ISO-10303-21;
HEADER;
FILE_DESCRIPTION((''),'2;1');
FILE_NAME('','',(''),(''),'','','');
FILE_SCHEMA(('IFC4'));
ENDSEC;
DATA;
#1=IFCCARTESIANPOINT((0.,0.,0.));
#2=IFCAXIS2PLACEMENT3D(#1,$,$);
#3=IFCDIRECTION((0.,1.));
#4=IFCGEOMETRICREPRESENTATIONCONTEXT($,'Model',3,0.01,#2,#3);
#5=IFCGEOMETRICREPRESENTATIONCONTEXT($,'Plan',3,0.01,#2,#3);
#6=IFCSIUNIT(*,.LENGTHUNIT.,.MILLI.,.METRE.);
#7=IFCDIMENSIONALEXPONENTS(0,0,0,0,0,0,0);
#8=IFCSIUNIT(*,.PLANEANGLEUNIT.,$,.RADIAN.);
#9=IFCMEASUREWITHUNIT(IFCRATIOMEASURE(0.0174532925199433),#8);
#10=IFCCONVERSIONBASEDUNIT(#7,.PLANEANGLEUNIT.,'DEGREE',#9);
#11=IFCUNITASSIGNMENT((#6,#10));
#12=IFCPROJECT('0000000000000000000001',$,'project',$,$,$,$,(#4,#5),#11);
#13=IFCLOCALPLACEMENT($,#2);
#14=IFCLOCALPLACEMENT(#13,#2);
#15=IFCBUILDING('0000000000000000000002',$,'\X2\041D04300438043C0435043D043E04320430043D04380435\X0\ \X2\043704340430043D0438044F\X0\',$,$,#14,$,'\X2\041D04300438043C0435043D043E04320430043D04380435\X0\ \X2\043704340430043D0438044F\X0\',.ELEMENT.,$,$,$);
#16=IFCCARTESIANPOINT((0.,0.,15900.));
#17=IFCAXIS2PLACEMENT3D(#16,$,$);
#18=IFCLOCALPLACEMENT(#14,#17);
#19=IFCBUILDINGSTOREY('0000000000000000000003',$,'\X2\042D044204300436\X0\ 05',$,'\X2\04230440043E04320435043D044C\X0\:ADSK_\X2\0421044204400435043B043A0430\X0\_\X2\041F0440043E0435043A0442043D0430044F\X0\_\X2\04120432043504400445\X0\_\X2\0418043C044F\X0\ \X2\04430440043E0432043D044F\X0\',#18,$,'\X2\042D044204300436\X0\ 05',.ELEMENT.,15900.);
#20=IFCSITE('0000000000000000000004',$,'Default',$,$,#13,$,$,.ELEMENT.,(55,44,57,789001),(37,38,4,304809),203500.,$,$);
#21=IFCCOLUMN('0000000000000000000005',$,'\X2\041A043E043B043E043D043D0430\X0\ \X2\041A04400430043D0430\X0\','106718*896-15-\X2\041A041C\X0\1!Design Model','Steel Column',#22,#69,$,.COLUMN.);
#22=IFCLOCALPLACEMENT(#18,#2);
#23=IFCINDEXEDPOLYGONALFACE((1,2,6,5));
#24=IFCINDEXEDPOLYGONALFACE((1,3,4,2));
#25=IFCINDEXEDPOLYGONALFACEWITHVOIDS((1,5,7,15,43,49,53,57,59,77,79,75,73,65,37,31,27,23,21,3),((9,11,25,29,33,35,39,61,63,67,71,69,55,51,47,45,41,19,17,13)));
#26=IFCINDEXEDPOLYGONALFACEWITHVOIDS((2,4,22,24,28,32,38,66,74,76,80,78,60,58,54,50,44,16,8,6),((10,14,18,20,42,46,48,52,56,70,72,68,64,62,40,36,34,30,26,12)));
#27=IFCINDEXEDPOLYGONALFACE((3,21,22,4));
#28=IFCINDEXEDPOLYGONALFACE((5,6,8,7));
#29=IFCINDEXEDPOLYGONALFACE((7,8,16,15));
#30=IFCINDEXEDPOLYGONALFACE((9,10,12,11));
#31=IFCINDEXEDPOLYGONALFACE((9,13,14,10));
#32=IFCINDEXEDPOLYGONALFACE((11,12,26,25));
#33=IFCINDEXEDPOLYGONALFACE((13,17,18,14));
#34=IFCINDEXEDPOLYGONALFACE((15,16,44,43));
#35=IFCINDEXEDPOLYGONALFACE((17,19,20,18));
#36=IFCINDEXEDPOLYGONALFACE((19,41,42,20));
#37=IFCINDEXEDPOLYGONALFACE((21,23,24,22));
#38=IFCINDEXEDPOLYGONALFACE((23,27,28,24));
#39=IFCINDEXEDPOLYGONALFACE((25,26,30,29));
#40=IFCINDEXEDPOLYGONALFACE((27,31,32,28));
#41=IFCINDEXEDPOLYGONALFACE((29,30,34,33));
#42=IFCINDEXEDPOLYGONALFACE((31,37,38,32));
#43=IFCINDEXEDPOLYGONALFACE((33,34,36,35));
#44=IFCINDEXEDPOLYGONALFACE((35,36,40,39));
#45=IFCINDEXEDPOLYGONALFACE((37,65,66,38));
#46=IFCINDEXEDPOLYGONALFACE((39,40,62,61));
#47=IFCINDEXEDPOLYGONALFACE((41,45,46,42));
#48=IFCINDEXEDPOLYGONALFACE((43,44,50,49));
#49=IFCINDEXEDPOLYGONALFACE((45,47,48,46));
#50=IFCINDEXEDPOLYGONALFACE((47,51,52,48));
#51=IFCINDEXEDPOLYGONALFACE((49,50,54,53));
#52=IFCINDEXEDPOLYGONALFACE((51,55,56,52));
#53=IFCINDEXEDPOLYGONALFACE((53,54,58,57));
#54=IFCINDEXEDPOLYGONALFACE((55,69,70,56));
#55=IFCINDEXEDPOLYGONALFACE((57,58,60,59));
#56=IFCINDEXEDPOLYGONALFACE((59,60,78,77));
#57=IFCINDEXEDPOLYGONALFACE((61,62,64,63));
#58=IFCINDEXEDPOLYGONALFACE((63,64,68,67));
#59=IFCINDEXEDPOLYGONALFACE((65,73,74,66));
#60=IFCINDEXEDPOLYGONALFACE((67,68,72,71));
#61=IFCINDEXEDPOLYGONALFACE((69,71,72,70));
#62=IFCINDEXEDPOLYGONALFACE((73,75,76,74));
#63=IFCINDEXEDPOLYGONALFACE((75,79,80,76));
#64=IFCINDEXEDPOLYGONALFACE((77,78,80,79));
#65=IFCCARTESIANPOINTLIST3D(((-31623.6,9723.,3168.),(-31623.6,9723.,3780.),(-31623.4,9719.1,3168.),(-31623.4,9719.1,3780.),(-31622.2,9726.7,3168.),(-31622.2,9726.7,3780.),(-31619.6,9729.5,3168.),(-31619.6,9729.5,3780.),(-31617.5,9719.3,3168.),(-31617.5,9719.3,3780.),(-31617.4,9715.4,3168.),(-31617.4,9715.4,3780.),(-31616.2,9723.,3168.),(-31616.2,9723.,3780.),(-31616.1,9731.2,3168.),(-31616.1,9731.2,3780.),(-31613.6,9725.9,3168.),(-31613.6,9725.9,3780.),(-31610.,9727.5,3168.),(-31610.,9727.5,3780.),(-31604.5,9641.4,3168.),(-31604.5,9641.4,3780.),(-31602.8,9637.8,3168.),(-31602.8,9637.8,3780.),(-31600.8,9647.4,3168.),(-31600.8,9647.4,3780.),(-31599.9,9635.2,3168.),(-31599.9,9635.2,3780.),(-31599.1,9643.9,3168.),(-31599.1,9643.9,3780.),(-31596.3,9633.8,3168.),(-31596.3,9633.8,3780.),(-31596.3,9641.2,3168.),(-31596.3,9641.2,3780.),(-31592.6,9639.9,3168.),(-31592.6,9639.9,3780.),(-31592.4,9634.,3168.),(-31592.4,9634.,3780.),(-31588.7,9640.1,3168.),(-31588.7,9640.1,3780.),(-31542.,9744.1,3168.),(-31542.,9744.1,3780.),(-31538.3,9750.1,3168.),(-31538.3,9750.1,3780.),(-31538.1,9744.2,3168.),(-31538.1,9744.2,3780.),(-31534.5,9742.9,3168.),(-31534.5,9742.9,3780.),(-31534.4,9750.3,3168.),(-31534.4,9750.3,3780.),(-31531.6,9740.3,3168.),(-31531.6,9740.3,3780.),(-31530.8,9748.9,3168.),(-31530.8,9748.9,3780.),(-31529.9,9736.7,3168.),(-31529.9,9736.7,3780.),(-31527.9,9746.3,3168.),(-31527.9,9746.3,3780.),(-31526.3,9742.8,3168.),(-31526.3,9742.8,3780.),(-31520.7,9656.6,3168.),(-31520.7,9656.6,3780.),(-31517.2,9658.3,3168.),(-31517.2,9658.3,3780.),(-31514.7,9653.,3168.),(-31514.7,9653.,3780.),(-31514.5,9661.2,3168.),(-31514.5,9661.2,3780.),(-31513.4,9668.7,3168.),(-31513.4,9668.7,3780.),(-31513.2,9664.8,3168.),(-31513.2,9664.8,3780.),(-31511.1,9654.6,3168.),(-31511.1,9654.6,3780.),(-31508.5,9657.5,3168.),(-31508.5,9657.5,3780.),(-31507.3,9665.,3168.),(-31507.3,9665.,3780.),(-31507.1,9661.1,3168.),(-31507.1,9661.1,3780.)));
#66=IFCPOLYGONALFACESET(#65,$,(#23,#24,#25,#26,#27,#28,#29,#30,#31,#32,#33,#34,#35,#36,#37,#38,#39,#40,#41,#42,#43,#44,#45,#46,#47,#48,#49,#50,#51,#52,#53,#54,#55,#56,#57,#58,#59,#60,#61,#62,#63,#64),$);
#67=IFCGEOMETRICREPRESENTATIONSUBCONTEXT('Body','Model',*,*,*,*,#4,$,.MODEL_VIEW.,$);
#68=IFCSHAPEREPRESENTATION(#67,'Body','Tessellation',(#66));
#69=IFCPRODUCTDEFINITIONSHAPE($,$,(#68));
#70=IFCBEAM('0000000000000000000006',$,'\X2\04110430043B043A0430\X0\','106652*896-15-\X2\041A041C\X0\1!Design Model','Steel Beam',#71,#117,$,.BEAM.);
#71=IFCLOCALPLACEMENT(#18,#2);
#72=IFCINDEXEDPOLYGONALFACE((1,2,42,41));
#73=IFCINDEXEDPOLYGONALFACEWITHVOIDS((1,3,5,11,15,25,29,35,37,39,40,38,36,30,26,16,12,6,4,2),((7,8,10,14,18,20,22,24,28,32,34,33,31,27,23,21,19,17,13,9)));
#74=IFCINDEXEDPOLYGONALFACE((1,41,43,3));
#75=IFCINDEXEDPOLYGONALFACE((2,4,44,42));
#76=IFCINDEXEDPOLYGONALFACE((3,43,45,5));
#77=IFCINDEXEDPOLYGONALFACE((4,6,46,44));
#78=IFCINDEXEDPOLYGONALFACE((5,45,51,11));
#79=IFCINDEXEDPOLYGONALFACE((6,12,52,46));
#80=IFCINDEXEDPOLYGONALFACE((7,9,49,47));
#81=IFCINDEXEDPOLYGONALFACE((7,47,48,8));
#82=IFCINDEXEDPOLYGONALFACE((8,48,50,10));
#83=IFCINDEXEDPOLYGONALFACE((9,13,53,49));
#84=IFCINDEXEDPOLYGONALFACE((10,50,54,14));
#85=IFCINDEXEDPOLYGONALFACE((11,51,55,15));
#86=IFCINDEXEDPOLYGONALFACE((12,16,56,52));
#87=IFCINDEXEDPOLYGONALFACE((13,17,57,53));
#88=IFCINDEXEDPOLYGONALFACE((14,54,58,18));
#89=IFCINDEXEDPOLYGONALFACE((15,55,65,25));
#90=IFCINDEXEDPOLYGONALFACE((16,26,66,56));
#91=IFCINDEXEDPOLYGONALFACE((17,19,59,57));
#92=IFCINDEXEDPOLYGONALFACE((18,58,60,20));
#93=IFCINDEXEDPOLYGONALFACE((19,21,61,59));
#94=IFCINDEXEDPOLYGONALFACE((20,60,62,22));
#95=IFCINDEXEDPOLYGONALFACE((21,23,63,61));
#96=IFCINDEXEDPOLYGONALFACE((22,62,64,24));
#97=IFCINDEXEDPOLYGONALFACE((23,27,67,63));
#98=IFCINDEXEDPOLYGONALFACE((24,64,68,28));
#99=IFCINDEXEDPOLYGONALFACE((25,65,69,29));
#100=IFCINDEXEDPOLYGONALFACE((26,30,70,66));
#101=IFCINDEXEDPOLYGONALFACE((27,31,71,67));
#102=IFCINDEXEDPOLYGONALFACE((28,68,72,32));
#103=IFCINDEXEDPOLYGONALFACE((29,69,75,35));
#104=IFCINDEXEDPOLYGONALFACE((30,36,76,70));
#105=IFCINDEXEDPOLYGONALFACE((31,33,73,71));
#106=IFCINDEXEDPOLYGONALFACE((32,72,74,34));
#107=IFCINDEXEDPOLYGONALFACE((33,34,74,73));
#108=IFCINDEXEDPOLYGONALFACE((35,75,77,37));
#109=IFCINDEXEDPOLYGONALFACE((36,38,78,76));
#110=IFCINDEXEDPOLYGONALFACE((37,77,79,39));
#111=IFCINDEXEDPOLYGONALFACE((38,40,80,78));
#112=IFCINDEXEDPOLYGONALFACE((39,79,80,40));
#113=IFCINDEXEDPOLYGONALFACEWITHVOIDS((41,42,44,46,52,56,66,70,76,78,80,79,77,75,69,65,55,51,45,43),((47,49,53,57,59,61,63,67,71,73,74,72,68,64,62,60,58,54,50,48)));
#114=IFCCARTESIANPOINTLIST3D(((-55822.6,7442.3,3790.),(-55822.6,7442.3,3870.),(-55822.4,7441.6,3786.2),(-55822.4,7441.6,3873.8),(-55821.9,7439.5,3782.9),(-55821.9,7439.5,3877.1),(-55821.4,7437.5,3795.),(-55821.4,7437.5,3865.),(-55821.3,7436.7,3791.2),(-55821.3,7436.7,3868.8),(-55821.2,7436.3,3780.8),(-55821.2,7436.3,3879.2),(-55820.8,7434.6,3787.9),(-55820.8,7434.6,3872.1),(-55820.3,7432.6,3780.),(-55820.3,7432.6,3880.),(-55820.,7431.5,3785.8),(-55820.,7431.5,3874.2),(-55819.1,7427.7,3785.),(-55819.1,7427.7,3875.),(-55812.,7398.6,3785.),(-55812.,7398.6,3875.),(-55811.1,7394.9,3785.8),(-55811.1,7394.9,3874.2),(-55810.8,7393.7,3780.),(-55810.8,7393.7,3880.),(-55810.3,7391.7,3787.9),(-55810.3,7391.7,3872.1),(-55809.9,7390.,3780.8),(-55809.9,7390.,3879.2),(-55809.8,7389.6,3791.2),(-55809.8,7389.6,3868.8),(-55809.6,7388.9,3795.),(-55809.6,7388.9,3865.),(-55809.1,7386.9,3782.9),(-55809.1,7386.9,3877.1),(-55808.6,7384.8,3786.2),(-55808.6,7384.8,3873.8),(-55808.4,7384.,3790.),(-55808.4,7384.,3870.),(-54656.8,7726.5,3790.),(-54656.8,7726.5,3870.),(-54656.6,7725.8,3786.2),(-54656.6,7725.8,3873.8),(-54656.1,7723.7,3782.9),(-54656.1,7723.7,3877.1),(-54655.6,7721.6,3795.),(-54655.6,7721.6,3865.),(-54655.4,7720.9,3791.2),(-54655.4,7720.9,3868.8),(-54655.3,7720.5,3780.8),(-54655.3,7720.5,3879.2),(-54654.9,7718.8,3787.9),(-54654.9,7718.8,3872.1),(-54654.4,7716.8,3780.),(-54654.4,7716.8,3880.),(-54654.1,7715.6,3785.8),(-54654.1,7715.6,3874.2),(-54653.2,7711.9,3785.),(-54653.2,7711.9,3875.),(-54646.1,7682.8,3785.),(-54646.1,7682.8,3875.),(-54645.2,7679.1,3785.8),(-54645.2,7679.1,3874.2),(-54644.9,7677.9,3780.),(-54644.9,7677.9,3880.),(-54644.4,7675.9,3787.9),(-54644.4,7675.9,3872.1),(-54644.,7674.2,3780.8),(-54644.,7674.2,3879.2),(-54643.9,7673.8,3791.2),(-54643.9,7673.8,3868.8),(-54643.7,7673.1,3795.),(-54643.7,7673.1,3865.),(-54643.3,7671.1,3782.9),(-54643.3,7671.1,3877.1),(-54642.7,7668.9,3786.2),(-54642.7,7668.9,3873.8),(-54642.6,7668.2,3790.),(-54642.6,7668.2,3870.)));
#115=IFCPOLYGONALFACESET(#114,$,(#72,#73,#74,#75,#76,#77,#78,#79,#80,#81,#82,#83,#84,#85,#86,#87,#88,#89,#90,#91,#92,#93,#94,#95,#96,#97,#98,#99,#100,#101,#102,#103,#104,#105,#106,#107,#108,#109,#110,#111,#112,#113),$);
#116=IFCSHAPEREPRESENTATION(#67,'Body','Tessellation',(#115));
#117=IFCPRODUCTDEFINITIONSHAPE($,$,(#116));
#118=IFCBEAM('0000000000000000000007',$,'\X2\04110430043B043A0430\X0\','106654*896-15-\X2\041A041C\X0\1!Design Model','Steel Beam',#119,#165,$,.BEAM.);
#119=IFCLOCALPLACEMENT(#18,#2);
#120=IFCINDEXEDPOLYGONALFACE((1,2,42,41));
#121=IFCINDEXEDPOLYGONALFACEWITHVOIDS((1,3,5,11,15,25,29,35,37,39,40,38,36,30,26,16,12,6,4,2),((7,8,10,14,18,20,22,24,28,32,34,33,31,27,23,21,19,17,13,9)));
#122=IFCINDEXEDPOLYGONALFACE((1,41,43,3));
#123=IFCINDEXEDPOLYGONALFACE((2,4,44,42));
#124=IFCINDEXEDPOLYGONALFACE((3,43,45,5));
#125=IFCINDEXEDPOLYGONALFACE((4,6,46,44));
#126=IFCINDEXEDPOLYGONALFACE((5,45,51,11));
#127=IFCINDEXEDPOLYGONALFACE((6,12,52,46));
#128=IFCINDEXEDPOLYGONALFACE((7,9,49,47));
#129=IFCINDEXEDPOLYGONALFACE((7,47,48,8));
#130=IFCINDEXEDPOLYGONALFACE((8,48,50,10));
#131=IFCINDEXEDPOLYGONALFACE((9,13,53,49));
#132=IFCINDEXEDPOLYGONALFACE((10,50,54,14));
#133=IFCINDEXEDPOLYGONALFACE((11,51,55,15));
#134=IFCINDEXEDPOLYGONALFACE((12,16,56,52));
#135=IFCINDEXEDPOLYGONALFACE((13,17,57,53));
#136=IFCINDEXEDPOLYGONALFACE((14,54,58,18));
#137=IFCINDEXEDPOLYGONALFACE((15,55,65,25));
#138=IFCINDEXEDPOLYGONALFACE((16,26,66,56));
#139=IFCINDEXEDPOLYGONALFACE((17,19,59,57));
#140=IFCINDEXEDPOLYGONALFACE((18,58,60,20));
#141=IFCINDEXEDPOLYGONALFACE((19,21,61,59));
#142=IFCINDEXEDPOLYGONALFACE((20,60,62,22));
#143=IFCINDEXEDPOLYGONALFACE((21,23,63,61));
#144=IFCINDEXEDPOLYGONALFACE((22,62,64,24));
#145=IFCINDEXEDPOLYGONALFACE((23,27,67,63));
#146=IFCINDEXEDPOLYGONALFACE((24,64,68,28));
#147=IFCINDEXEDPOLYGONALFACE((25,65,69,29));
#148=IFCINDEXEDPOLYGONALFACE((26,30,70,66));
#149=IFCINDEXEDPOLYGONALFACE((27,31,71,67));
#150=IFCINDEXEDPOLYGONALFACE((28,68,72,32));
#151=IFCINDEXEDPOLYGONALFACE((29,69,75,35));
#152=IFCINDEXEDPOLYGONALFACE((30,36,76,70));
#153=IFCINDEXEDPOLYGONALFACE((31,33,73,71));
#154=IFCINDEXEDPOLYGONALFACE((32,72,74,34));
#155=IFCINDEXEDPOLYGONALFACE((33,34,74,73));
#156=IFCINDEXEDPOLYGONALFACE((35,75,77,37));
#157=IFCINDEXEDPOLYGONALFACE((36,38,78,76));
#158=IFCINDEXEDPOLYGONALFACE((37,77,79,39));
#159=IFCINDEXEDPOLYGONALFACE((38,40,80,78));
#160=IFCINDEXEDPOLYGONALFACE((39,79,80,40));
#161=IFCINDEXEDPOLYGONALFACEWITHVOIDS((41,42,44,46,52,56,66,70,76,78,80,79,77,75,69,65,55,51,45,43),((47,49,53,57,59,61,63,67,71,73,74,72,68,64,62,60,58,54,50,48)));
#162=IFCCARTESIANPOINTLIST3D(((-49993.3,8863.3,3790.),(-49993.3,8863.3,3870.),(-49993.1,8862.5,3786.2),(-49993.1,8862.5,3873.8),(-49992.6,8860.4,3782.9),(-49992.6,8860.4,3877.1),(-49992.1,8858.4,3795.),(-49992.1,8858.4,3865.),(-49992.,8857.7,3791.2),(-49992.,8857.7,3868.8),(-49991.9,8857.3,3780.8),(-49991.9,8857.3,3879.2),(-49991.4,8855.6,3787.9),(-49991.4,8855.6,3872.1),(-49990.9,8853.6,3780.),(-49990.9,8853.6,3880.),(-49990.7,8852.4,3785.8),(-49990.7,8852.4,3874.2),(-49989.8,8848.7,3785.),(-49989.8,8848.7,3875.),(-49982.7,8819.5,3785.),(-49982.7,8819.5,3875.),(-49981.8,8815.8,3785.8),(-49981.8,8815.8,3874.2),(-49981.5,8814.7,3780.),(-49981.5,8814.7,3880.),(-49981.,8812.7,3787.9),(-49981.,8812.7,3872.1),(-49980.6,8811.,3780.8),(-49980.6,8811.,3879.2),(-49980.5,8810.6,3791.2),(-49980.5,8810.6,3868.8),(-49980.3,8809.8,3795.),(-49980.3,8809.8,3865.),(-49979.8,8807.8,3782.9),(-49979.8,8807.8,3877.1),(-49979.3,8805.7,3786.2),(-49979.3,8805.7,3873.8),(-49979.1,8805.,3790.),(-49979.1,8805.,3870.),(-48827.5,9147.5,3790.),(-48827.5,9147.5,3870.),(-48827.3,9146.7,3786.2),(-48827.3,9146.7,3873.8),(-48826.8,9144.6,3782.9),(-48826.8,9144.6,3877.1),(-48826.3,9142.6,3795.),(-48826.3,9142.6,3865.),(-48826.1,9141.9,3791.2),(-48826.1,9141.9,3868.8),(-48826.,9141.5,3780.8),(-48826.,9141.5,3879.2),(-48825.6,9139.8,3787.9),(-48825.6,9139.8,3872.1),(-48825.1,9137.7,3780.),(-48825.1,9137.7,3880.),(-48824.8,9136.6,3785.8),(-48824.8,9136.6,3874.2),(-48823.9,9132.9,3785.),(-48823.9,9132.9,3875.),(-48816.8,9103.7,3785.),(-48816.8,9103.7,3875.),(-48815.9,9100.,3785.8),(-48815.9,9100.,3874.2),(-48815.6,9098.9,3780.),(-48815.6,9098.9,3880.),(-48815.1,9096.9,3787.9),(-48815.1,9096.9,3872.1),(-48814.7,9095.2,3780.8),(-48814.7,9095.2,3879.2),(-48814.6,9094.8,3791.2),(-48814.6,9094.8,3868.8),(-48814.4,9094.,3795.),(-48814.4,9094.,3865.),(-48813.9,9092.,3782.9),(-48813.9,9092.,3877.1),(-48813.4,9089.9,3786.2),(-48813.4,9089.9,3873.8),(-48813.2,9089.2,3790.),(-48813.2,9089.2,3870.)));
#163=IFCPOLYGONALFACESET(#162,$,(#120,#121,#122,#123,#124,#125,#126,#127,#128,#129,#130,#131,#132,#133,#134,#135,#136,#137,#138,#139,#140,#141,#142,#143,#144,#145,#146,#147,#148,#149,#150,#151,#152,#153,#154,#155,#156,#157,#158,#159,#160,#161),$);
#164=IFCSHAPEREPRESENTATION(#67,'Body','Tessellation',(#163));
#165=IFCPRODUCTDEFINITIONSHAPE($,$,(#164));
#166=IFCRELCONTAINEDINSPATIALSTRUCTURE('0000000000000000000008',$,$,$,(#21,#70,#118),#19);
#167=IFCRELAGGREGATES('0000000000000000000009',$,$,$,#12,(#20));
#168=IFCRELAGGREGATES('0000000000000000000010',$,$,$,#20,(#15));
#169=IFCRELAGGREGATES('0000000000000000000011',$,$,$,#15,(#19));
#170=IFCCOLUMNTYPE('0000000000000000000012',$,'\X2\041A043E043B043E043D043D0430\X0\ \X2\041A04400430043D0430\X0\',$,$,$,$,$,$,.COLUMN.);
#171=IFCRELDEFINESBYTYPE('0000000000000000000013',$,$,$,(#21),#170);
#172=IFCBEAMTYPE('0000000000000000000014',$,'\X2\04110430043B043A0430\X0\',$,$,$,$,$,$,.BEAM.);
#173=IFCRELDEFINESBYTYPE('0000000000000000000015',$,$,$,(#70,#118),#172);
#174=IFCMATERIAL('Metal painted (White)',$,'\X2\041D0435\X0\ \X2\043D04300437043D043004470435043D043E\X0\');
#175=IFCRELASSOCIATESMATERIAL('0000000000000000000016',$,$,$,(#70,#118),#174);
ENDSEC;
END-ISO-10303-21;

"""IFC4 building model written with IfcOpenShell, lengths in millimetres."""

from ifc_helpers import new_model, entity, si_unit, converted_unit, direction, frame, origin, place, context, subcontext, project, spatial, indexed_curve, outline, extrude, material, type_object, element, save


model = new_model("IFC4")

# Units and contexts
model_context = context("Model", 3, precision=0.01, world=origin(), true_north=direction((0.0, 1.0)))
plan_context = context("Plan", 3, precision=0.01, world=origin(), true_north=direction((0.0, 1.0)))
body_context = subcontext(model_context, "Body", "Model", "MODEL_VIEW")
ifc_project = project(units=[si_unit("LENGTHUNIT", "METRE", prefix="MILLI"), converted_unit("PLANEANGLEUNIT", "DEGREE", entity("IfcRatioMeasure", 0.0174532925199433), si_unit("PLANEANGLEUNIT", "RADIAN"), dimensions=[0, 0, 0, 0, 0, 0, 0])], contexts=[model_context, plan_context])

# Site, building, storey
site_placement = place(None, origin())
site = spatial("IfcSite", under=ifc_project, at=site_placement, Name="Default", CompositionType="ELEMENT", RefLatitude=(55, 44, 57, 789001), RefLongitude=(37, 38, 4, 304809), RefElevation=203500.0)
building_placement = place(site_placement, origin())
building = spatial("IfcBuilding", under=site, at=building_placement, Name="Наименование здания", LongName="Наименование здания", CompositionType="ELEMENT")
storey_placement = place(building_placement, frame((0.0, 0.0, 15900.0)))
storey = spatial("IfcBuildingStorey", under=building, at=storey_placement, Name="Этаж 05", ObjectType="Уровень:ADSK_Стрелка_Проектная_Вверх_Имя уровня", LongName="Этаж 05", CompositionType="ELEMENT", Elevation=15900.0)

# Column
column_type_1 = type_object("IfcColumnType", Name="Колонна Крана", PredefinedType="COLUMN")
column_1_placement = place(storey_placement, origin())
element("IfcColumn", 1, at=column_1_placement, inside=storey, type_object=column_type_1, Name="Колонна Крана", Description="106718*896-15-КМ1!Design Model", ObjectType="Steel Column", PredefinedType="COLUMN", context=body_context, shape_type="SweptSolid", body=[
    extrude(outline(indexed_curve([(29.5, -56.8), (33.4, -56.8), (37.0, -55.3), (39.7, -52.6), (41.2, -49.0), (56.8, 29.5), (56.8, 33.4), (55.3, 37.0), (52.6, 39.7), (49.0, 41.2), (-29.5, 56.8), (-33.4, 56.8), (-37.0, 55.3), (-39.7, 52.6), (-41.2, 49.0), (-56.8, -29.5), (-56.8, -33.4), (-55.3, -37.0), (-52.6, -39.7), (-49.0, -41.2), (29.5, -56.8)], self_intersect=False), holes=[indexed_curve([(-43.1, -37.3), (-46.7, -35.8), (-49.5, -33.1), (-51.0, -29.5), (-51.0, -25.5), (-37.3, 43.1), (-35.8, 46.7), (-33.1, 49.5), (-29.5, 51.0), (-25.5, 51.0), (43.1, 37.3), (46.7, 35.8), (49.5, 33.1), (51.0, 29.5), (51.0, 25.5), (37.3, -43.1), (35.8, -46.7), (33.1, -49.5), (29.5, -51.0), (25.5, -51.0), (-43.1, -37.3)], self_intersect=False)]), frame((-31565.4, 9692.1, 3168.0), z_axis=(0.0, 0.0, 1.0), x_axis=(-0.906681, -0.421816, 0.0)), (0.0, 0.0, 1.0), 612.0),
])

# Beams
ifc_material = material(Name="Metal painted (White)", Category="Не назначено")
beam_type = type_object("IfcBeamType", Name="Балка", PredefinedType="BEAM")
beam_1_placement = place(storey_placement, origin())
element("IfcBeam", 2, at=beam_1_placement, inside=storey, type_object=beam_type, material=ifc_material, Name="Балка", Description="106652*896-15-КМ1!Design Model", ObjectType="Steel Beam", PredefinedType="BEAM", context=body_context, shape_type="SweptSolid", body=[
    extrude(outline(indexed_curve([(9.9, -52.9), (13.8, -52.9), (17.4, -51.4), (20.1, -48.7), (21.6, -45.1), (37.2, 33.4), (37.2, 37.3), (35.7, 40.9), (33.0, 43.6), (29.4, 45.1), (-9.9, 52.9), (-13.8, 52.9), (-17.4, 51.4), (-20.1, 48.7), (-21.6, 45.1), (-37.2, -33.4), (-37.2, -37.3), (-35.7, -40.9), (-33.0, -43.6), (-29.4, -45.1), (9.9, -52.9)], self_intersect=False), holes=[indexed_curve([(-31.3, -29.5), (-17.7, 39.2), (-16.2, 42.8), (-13.4, 45.6), (-9.8, 47.1), (-5.9, 47.1), (23.5, 41.2), (27.1, 39.7), (29.9, 37.0), (31.3, 33.4), (31.3, 29.5), (17.7, -39.2), (16.2, -42.8), (13.4, -45.6), (9.8, -47.1), (5.9, -47.1), (-23.5, -41.2), (-27.1, -39.7), (-29.9, -37.0), (-31.3, -33.4), (-31.3, -29.5)], self_intersect=False)]), frame((-55815.5, 7413.2, 3830.0), z_axis=(0.971552, 0.236826, 0.0), x_axis=(-0.232276, 0.952884, 0.19509)), (0.0, 0.0, 1.0), 1200.0),
])
beam_2_placement = place(storey_placement, origin())
element("IfcBeam", 3, at=beam_2_placement, inside=storey, type_object=beam_type, material=ifc_material, Name="Балка", Description="106654*896-15-КМ1!Design Model", ObjectType="Steel Beam", PredefinedType="BEAM", context=body_context, shape_type="SweptSolid", body=[
    extrude(outline(indexed_curve([(9.9, -52.9), (13.8, -52.9), (17.4, -51.4), (20.1, -48.7), (21.6, -45.1), (37.2, 33.4), (37.2, 37.3), (35.7, 40.9), (33.0, 43.6), (29.4, 45.1), (-9.9, 52.9), (-13.8, 52.9), (-17.4, 51.4), (-20.1, 48.7), (-21.6, 45.1), (-37.2, -33.4), (-37.2, -37.3), (-35.7, -40.9), (-33.0, -43.6), (-29.4, -45.1), (9.9, -52.9)], self_intersect=False), holes=[indexed_curve([(-31.3, -29.5), (-17.7, 39.2), (-16.2, 42.8), (-13.4, 45.6), (-9.8, 47.1), (-5.9, 47.1), (23.5, 41.2), (27.1, 39.7), (29.9, 37.0), (31.3, 33.4), (31.3, 29.5), (17.7, -39.2), (16.2, -42.8), (13.4, -45.6), (9.8, -47.1), (5.9, -47.1), (-23.5, -41.2), (-27.1, -39.7), (-29.9, -37.0), (-31.3, -33.4), (-31.3, -29.5)], self_intersect=False)]), frame((-49986.2, 8834.1, 3830.0), z_axis=(0.971552, 0.236826, 0.0), x_axis=(-0.232276, 0.952884, 0.19509)), (0.0, 0.0, 1.0), 1200.0),
])

save(model, "model.ifc")
